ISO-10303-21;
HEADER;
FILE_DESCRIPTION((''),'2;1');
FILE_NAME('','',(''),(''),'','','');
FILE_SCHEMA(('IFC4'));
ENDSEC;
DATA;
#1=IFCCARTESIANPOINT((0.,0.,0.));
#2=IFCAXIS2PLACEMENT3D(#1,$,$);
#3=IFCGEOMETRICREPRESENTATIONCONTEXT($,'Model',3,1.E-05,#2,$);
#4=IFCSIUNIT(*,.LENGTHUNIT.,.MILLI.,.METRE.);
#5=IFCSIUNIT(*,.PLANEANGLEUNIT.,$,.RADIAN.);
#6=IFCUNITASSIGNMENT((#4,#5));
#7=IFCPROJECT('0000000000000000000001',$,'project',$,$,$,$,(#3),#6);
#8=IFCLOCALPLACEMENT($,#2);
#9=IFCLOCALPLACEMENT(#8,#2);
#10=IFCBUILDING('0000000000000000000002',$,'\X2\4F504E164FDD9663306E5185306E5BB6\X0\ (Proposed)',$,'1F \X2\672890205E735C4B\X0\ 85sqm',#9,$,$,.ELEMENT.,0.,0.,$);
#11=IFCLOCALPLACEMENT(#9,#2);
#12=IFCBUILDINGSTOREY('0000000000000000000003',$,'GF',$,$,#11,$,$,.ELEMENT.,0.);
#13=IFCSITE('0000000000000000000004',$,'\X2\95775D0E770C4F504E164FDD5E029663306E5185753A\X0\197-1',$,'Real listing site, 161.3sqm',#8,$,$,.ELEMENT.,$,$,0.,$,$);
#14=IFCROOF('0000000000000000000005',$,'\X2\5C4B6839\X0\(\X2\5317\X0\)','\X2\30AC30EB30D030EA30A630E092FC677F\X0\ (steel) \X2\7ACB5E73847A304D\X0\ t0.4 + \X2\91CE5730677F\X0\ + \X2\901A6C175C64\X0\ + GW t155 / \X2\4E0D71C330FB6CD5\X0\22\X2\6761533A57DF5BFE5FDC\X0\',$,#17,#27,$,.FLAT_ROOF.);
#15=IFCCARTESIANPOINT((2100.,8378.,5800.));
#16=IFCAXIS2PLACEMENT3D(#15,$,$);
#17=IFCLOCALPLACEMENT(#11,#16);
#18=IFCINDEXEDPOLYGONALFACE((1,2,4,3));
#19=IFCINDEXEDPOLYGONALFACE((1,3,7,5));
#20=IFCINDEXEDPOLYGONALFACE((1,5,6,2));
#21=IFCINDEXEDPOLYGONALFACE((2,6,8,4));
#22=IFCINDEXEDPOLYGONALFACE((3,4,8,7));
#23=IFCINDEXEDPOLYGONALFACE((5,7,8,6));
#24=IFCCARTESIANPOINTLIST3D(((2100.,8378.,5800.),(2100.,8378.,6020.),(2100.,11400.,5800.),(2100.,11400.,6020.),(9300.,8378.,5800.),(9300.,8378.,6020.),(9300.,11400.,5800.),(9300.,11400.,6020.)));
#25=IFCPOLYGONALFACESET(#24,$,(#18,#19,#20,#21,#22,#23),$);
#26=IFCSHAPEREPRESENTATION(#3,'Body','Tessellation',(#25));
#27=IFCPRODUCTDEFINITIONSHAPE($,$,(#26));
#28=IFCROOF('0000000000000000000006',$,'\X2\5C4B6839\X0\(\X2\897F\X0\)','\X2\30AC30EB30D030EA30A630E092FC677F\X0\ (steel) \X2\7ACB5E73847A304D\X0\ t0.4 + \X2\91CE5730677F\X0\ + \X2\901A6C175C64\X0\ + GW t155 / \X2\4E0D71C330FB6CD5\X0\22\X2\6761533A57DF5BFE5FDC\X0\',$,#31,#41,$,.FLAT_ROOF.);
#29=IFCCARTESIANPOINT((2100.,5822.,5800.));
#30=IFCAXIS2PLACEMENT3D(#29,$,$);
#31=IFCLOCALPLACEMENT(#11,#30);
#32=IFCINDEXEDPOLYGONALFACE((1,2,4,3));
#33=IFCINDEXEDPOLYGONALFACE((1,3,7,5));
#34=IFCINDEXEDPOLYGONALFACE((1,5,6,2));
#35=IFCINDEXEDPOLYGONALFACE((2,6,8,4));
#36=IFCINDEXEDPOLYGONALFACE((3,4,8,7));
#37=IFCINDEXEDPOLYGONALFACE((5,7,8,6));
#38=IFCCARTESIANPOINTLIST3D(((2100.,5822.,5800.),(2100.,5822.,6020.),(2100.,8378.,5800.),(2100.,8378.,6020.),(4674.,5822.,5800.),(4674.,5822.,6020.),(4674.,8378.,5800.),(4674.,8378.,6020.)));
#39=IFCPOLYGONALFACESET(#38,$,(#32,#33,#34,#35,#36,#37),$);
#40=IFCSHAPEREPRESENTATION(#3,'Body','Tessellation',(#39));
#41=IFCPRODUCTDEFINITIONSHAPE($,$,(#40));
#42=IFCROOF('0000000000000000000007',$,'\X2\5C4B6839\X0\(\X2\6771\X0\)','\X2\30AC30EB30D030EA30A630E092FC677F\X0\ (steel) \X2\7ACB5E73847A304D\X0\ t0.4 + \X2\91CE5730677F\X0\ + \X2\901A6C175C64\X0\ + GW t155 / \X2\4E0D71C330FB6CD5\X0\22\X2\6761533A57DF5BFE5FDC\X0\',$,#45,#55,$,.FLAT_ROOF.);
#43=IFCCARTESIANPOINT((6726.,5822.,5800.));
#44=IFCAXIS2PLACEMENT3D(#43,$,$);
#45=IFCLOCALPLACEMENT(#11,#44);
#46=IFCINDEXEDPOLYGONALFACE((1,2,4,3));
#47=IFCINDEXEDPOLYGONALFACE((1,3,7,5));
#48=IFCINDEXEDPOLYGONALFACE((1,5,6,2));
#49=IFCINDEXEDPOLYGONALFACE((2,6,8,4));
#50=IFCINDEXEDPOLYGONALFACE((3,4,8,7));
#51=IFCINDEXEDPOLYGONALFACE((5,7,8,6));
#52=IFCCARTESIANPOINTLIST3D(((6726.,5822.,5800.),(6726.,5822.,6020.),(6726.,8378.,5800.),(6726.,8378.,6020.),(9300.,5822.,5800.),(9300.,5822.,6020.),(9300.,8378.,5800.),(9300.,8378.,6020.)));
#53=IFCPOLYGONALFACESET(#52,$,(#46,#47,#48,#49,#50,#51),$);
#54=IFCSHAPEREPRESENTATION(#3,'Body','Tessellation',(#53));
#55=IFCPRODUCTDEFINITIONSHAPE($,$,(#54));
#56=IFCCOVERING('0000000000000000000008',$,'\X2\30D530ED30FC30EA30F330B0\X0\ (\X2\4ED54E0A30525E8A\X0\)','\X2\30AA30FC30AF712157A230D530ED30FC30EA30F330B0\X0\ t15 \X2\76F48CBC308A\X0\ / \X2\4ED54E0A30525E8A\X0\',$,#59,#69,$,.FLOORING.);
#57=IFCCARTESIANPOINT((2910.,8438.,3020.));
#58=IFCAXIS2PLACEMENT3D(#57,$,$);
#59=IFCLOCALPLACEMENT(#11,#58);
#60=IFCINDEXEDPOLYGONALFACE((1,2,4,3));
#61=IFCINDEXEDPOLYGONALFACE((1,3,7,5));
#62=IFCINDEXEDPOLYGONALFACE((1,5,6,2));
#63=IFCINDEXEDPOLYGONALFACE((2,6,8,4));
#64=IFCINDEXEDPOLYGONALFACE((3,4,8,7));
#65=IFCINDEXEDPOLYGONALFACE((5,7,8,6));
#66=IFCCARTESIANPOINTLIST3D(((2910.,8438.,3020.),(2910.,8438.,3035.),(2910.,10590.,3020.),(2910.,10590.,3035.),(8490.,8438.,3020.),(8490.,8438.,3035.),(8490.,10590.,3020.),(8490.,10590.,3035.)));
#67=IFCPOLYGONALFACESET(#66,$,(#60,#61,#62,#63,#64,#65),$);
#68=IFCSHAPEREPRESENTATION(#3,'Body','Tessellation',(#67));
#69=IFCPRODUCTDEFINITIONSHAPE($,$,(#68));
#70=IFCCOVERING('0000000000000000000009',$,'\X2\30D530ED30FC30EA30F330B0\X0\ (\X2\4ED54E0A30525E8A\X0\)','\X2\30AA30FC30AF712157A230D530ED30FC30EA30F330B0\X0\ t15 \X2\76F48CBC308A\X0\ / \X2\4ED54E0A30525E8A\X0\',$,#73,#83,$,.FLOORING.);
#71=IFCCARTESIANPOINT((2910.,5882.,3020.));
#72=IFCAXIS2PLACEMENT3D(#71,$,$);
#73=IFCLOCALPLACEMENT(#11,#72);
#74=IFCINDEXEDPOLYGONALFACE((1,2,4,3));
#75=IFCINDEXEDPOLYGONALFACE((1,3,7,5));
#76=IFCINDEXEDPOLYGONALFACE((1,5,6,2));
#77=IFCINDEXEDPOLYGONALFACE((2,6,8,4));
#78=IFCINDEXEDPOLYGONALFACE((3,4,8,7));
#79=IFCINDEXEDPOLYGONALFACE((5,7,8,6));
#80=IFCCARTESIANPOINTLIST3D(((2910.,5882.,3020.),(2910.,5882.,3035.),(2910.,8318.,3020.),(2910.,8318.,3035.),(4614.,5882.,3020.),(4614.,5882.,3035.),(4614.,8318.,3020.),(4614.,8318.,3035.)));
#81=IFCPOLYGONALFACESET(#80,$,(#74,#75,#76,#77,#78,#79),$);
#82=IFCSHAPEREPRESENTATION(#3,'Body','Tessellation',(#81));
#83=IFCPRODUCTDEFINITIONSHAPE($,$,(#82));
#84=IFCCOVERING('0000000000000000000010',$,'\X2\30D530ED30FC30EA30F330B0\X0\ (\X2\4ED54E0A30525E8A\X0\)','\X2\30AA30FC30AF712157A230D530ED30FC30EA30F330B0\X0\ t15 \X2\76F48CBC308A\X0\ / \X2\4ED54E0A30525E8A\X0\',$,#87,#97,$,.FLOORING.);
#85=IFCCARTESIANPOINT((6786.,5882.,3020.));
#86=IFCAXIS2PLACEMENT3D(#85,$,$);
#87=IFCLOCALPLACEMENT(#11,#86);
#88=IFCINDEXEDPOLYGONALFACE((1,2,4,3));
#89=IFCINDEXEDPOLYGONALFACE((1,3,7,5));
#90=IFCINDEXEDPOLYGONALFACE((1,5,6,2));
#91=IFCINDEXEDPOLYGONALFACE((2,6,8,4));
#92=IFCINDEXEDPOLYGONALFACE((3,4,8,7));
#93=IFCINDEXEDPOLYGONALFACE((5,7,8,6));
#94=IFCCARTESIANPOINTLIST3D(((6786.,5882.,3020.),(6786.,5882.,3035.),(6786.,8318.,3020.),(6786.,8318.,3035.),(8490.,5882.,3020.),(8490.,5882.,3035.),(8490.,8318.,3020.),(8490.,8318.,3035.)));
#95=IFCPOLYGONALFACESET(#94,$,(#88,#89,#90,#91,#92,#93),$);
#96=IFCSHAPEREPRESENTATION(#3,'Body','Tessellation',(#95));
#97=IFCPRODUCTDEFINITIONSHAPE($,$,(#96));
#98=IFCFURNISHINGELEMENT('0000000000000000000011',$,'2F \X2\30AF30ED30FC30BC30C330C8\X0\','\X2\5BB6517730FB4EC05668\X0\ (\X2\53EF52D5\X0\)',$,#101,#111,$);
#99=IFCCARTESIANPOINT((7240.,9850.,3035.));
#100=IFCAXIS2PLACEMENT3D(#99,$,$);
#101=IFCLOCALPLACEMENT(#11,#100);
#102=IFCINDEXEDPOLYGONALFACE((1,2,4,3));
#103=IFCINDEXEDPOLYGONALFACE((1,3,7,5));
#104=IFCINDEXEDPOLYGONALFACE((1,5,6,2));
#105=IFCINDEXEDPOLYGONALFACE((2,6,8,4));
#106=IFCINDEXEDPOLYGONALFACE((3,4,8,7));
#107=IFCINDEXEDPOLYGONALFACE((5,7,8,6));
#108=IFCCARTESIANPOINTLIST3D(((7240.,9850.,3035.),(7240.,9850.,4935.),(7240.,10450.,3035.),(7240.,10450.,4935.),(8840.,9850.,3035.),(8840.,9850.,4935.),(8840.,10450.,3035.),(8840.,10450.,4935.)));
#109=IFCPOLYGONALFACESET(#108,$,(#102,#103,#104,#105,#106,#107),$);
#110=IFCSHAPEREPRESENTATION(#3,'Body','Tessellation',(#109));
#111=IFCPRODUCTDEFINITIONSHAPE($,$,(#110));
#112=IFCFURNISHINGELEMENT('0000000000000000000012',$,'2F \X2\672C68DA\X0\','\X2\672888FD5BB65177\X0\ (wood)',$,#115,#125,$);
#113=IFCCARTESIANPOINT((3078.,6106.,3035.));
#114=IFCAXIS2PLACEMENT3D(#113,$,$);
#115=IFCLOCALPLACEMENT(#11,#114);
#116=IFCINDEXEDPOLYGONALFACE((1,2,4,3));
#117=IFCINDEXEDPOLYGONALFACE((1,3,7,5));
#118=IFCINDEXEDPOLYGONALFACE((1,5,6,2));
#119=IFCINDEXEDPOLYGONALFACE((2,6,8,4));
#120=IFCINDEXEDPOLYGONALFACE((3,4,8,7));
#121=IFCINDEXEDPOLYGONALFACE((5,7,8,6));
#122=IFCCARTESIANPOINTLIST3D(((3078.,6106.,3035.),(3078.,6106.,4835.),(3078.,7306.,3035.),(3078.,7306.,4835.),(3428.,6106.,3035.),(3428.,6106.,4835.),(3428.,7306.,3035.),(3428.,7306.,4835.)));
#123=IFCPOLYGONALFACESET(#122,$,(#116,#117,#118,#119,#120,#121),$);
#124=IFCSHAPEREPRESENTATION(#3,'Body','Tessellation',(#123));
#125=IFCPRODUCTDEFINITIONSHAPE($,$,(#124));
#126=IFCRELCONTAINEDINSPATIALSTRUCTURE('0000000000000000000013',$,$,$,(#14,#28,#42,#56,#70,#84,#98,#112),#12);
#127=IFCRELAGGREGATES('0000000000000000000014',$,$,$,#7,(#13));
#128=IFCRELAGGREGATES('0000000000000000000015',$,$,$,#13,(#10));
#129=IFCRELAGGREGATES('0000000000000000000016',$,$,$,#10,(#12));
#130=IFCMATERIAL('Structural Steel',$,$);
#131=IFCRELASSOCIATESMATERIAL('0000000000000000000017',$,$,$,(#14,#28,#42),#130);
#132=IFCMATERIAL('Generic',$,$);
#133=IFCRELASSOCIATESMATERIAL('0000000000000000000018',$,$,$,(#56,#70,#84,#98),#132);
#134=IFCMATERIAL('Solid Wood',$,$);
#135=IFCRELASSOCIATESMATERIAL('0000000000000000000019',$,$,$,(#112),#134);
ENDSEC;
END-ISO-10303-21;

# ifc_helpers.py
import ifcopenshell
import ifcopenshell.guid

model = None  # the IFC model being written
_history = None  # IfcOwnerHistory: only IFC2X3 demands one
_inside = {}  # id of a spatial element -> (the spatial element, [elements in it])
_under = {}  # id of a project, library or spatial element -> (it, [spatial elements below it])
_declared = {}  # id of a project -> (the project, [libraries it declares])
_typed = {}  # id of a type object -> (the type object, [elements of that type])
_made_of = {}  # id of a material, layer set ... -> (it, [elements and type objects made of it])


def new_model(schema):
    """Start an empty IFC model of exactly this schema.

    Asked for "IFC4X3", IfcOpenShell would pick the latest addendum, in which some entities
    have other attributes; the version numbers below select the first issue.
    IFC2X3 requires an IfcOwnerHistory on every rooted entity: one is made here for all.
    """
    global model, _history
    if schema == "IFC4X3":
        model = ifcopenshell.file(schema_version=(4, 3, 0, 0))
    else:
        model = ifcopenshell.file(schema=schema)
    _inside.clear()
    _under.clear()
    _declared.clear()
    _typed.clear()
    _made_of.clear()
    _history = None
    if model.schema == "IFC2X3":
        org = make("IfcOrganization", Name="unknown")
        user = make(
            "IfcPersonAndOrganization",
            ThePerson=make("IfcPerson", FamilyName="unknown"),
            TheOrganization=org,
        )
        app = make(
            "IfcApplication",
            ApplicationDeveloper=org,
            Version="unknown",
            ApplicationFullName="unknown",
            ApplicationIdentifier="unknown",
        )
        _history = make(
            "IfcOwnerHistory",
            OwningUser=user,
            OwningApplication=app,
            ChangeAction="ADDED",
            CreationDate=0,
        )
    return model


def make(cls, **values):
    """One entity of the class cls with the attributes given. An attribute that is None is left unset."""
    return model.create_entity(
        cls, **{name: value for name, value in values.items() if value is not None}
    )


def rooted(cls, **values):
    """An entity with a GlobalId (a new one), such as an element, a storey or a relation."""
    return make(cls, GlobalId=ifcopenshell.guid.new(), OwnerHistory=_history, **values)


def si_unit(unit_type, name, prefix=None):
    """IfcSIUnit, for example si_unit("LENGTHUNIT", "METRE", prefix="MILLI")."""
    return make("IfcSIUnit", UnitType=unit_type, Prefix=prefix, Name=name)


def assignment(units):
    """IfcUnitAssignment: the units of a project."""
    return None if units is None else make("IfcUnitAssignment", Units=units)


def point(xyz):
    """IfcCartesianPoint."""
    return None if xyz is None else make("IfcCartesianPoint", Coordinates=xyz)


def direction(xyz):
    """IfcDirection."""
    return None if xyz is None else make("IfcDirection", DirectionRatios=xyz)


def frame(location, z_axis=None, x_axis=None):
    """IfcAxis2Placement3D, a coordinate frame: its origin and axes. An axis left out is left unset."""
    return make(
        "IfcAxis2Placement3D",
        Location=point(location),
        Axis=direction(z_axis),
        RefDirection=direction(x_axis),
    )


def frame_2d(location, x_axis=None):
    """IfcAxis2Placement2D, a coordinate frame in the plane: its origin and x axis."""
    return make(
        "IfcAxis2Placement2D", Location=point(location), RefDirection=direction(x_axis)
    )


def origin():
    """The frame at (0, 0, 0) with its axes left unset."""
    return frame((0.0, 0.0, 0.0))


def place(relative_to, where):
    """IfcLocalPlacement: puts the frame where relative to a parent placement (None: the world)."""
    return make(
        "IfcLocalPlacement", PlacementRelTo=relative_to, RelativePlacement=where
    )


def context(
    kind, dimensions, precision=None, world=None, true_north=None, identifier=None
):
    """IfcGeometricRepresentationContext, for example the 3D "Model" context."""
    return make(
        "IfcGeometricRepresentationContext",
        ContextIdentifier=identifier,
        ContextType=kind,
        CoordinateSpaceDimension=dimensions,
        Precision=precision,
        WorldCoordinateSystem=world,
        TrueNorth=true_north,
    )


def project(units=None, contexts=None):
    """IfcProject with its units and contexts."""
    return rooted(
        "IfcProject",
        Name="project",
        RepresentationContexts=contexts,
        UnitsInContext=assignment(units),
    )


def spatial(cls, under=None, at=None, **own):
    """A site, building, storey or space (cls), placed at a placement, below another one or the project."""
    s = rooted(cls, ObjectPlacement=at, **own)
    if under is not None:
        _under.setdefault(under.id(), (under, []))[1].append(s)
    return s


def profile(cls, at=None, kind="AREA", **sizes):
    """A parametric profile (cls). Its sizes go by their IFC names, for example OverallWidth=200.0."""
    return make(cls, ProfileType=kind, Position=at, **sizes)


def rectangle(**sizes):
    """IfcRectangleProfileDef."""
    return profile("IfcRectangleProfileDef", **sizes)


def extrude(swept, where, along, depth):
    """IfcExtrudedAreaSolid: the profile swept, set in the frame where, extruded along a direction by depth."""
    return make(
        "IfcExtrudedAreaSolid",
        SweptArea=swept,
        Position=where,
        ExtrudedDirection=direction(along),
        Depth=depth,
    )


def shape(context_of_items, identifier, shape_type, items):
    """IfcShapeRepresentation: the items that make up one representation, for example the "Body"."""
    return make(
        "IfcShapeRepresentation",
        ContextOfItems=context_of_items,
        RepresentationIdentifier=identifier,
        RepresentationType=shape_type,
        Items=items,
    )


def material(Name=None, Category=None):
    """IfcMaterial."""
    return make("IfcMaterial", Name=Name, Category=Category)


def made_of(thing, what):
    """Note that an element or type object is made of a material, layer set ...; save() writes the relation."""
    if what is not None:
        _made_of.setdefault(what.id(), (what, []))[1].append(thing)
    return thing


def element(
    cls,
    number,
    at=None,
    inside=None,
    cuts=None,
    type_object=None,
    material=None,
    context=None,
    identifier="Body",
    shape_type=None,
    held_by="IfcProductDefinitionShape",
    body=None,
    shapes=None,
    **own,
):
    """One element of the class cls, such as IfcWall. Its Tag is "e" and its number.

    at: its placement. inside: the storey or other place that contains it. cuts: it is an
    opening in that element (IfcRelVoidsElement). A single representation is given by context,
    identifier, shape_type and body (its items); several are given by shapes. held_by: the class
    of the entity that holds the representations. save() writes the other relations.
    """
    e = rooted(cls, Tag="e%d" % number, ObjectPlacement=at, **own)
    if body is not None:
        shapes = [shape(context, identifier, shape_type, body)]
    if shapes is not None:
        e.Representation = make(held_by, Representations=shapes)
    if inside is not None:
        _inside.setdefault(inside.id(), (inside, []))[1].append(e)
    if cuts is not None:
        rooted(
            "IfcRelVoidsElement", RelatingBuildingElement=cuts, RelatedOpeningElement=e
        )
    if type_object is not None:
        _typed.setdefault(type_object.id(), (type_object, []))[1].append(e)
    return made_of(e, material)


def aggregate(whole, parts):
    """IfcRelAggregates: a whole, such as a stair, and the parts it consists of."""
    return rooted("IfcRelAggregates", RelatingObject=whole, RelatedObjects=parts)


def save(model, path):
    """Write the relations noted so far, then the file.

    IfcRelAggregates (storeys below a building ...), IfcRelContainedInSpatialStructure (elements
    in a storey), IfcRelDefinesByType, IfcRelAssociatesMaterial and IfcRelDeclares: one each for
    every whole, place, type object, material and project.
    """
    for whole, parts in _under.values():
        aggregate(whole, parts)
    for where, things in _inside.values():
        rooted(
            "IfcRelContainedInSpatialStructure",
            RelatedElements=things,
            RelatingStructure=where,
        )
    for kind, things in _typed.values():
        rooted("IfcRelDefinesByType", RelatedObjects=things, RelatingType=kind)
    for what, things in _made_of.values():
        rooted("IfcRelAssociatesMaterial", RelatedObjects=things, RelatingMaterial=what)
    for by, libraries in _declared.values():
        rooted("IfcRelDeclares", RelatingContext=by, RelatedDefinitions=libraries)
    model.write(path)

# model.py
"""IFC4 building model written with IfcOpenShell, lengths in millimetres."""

from ifc_helpers import new_model, si_unit, frame, frame_2d, origin, place, context, project, spatial, rectangle, extrude, material, element, save


model = new_model("IFC4")

# Units and contexts
model_context = context("Model", 3, precision=1e-05, world=origin())
ifc_project = project(units=[si_unit("LENGTHUNIT", "METRE", prefix="MILLI"), si_unit("PLANEANGLEUNIT", "RADIAN")], contexts=[model_context])

# Site, building, storey
site_placement = place(None, origin())
site = spatial("IfcSite", under=ifc_project, at=site_placement, Name="長崎県佐世保市陣の内町197-1", ObjectType="Real listing site, 161.3sqm", CompositionType="ELEMENT", RefElevation=0.0)
building_placement = place(site_placement, origin())
building = spatial("IfcBuilding", under=site, at=building_placement, Name="佐世保陣の内の家 (Proposed)", ObjectType="1F 木造平屋 85sqm", CompositionType="ELEMENT", ElevationOfRefHeight=0.0, ElevationOfTerrain=0.0)
storey_placement = place(building_placement, origin())
storey = spatial("IfcBuildingStorey", under=building, at=storey_placement, Name="GF", CompositionType="ELEMENT", Elevation=0.0)

# Shared definitions
ifc_material_1 = material(Name="Solid Wood")

# Shared definitions
ifc_material_2 = material(Name="Generic")

# Roofs
ifc_material_3 = material(Name="Structural Steel")
for number, where, name in (
    (1, (2100.0, 8378.0, 5800.0), "屋根(北)"),
):
    element("IfcRoof", number, at=place(storey_placement, frame(where)), inside=storey, material=ifc_material_3, Name=name, Description="ガルバリウム鋼板 (steel) 立平葺き t0.4 + 野地板 + 通気層 + GW t155 / 不燃・法22条区域対応", PredefinedType="FLAT_ROOF", context=model_context, shape_type="SweptSolid", body=[
        extrude(rectangle(XDim=7200.0, YDim=3022.0, at=frame_2d((3600.0, 1511.0))), frame((2100.0, 8378.0, 5800.0)), (0.0, 0.0, 1.0), 220.0),
    ])
roof_1_placement = place(storey_placement, frame((2100.0, 5822.0, 5800.0)))
element("IfcRoof", 2, at=roof_1_placement, inside=storey, material=ifc_material_3, Name="屋根(西)", Description="ガルバリウム鋼板 (steel) 立平葺き t0.4 + 野地板 + 通気層 + GW t155 / 不燃・法22条区域対応", PredefinedType="FLAT_ROOF", context=model_context, shape_type="SweptSolid", body=[
    extrude(rectangle(XDim=2574.0, YDim=2556.0, at=frame_2d((1287.0, 1278.0))), frame((2100.0, 5822.0, 5800.0)), (0.0, 0.0, 1.0), 220.0),
])
roof_2_placement = place(storey_placement, frame((6726.0, 5822.0, 5800.0)))
element("IfcRoof", 3, at=roof_2_placement, inside=storey, material=ifc_material_3, Name="屋根(東)", Description="ガルバリウム鋼板 (steel) 立平葺き t0.4 + 野地板 + 通気層 + GW t155 / 不燃・法22条区域対応", PredefinedType="FLAT_ROOF", context=model_context, shape_type="SweptSolid", body=[
    extrude(rectangle(XDim=2574.0, YDim=2556.0, at=frame_2d((1287.0, 1278.0))), frame((6726.0, 5822.0, 5800.0)), (0.0, 0.0, 1.0), 220.0),
])

# Coverings
covering_1_placement = place(storey_placement, frame((2910.0, 8438.0, 3020.0)))
element("IfcCovering", 4, at=covering_1_placement, inside=storey, material=ifc_material_2, Name="フローリング (仕上げ床)", Description="オーク無垢フローリング t15 直貼り / 仕上げ床", PredefinedType="FLOORING", context=model_context, shape_type="SweptSolid", body=[
    extrude(rectangle(XDim=5580.0, YDim=2152.0, at=frame_2d((2790.0, 1076.0))), frame((2910.0, 8438.0, 3020.0)), (0.0, 0.0, 1.0), 15.0),
])
covering_2_placement = place(storey_placement, frame((2910.0, 5882.0, 3020.0)))
element("IfcCovering", 5, at=covering_2_placement, inside=storey, material=ifc_material_2, Name="フローリング (仕上げ床)", Description="オーク無垢フローリング t15 直貼り / 仕上げ床", PredefinedType="FLOORING", context=model_context, shape_type="SweptSolid", body=[
    extrude(rectangle(XDim=1704.0, YDim=2436.0, at=frame_2d((852.0, 1218.0))), frame((2910.0, 5882.0, 3020.0)), (0.0, 0.0, 1.0), 15.0),
])
covering_3_placement = place(storey_placement, frame((6786.0, 5882.0, 3020.0)))
element("IfcCovering", 6, at=covering_3_placement, inside=storey, material=ifc_material_2, Name="フローリング (仕上げ床)", Description="オーク無垢フローリング t15 直貼り / 仕上げ床", PredefinedType="FLOORING", context=model_context, shape_type="SweptSolid", body=[
    extrude(rectangle(XDim=1704.0, YDim=2436.0, at=frame_2d((852.0, 1218.0))), frame((6786.0, 5882.0, 3020.0)), (0.0, 0.0, 1.0), 15.0),
])

# Furnishing elements
furnishing_1_placement = place(storey_placement, frame((7240.0, 9850.0, 3035.0)))
element("IfcFurnishingElement", 7, at=furnishing_1_placement, inside=storey, material=ifc_material_2, Name="2F クローゼット", Description="家具・什器 (可動)", context=model_context, shape_type="SweptSolid", body=[
    extrude(rectangle(XDim=1600.0, YDim=600.0, at=frame_2d((800.0, 300.0))), frame((7240.0, 9850.0, 3035.0)), (0.0, 0.0, 1.0), 1900.0),
])
furnishing_2_placement = place(storey_placement, frame((3078.0, 6106.0, 3035.0)))
element("IfcFurnishingElement", 8, at=furnishing_2_placement, inside=storey, material=ifc_material_1, Name="2F 本棚", Description="木製家具 (wood)", context=model_context, shape_type="SweptSolid", body=[
    extrude(rectangle(XDim=350.0, YDim=1200.0, at=frame_2d((175.0, 600.0))), frame((3078.0, 6106.0, 3035.0)), (0.0, 0.0, 1.0), 1800.0),
])

save(model, "model.ifc")
